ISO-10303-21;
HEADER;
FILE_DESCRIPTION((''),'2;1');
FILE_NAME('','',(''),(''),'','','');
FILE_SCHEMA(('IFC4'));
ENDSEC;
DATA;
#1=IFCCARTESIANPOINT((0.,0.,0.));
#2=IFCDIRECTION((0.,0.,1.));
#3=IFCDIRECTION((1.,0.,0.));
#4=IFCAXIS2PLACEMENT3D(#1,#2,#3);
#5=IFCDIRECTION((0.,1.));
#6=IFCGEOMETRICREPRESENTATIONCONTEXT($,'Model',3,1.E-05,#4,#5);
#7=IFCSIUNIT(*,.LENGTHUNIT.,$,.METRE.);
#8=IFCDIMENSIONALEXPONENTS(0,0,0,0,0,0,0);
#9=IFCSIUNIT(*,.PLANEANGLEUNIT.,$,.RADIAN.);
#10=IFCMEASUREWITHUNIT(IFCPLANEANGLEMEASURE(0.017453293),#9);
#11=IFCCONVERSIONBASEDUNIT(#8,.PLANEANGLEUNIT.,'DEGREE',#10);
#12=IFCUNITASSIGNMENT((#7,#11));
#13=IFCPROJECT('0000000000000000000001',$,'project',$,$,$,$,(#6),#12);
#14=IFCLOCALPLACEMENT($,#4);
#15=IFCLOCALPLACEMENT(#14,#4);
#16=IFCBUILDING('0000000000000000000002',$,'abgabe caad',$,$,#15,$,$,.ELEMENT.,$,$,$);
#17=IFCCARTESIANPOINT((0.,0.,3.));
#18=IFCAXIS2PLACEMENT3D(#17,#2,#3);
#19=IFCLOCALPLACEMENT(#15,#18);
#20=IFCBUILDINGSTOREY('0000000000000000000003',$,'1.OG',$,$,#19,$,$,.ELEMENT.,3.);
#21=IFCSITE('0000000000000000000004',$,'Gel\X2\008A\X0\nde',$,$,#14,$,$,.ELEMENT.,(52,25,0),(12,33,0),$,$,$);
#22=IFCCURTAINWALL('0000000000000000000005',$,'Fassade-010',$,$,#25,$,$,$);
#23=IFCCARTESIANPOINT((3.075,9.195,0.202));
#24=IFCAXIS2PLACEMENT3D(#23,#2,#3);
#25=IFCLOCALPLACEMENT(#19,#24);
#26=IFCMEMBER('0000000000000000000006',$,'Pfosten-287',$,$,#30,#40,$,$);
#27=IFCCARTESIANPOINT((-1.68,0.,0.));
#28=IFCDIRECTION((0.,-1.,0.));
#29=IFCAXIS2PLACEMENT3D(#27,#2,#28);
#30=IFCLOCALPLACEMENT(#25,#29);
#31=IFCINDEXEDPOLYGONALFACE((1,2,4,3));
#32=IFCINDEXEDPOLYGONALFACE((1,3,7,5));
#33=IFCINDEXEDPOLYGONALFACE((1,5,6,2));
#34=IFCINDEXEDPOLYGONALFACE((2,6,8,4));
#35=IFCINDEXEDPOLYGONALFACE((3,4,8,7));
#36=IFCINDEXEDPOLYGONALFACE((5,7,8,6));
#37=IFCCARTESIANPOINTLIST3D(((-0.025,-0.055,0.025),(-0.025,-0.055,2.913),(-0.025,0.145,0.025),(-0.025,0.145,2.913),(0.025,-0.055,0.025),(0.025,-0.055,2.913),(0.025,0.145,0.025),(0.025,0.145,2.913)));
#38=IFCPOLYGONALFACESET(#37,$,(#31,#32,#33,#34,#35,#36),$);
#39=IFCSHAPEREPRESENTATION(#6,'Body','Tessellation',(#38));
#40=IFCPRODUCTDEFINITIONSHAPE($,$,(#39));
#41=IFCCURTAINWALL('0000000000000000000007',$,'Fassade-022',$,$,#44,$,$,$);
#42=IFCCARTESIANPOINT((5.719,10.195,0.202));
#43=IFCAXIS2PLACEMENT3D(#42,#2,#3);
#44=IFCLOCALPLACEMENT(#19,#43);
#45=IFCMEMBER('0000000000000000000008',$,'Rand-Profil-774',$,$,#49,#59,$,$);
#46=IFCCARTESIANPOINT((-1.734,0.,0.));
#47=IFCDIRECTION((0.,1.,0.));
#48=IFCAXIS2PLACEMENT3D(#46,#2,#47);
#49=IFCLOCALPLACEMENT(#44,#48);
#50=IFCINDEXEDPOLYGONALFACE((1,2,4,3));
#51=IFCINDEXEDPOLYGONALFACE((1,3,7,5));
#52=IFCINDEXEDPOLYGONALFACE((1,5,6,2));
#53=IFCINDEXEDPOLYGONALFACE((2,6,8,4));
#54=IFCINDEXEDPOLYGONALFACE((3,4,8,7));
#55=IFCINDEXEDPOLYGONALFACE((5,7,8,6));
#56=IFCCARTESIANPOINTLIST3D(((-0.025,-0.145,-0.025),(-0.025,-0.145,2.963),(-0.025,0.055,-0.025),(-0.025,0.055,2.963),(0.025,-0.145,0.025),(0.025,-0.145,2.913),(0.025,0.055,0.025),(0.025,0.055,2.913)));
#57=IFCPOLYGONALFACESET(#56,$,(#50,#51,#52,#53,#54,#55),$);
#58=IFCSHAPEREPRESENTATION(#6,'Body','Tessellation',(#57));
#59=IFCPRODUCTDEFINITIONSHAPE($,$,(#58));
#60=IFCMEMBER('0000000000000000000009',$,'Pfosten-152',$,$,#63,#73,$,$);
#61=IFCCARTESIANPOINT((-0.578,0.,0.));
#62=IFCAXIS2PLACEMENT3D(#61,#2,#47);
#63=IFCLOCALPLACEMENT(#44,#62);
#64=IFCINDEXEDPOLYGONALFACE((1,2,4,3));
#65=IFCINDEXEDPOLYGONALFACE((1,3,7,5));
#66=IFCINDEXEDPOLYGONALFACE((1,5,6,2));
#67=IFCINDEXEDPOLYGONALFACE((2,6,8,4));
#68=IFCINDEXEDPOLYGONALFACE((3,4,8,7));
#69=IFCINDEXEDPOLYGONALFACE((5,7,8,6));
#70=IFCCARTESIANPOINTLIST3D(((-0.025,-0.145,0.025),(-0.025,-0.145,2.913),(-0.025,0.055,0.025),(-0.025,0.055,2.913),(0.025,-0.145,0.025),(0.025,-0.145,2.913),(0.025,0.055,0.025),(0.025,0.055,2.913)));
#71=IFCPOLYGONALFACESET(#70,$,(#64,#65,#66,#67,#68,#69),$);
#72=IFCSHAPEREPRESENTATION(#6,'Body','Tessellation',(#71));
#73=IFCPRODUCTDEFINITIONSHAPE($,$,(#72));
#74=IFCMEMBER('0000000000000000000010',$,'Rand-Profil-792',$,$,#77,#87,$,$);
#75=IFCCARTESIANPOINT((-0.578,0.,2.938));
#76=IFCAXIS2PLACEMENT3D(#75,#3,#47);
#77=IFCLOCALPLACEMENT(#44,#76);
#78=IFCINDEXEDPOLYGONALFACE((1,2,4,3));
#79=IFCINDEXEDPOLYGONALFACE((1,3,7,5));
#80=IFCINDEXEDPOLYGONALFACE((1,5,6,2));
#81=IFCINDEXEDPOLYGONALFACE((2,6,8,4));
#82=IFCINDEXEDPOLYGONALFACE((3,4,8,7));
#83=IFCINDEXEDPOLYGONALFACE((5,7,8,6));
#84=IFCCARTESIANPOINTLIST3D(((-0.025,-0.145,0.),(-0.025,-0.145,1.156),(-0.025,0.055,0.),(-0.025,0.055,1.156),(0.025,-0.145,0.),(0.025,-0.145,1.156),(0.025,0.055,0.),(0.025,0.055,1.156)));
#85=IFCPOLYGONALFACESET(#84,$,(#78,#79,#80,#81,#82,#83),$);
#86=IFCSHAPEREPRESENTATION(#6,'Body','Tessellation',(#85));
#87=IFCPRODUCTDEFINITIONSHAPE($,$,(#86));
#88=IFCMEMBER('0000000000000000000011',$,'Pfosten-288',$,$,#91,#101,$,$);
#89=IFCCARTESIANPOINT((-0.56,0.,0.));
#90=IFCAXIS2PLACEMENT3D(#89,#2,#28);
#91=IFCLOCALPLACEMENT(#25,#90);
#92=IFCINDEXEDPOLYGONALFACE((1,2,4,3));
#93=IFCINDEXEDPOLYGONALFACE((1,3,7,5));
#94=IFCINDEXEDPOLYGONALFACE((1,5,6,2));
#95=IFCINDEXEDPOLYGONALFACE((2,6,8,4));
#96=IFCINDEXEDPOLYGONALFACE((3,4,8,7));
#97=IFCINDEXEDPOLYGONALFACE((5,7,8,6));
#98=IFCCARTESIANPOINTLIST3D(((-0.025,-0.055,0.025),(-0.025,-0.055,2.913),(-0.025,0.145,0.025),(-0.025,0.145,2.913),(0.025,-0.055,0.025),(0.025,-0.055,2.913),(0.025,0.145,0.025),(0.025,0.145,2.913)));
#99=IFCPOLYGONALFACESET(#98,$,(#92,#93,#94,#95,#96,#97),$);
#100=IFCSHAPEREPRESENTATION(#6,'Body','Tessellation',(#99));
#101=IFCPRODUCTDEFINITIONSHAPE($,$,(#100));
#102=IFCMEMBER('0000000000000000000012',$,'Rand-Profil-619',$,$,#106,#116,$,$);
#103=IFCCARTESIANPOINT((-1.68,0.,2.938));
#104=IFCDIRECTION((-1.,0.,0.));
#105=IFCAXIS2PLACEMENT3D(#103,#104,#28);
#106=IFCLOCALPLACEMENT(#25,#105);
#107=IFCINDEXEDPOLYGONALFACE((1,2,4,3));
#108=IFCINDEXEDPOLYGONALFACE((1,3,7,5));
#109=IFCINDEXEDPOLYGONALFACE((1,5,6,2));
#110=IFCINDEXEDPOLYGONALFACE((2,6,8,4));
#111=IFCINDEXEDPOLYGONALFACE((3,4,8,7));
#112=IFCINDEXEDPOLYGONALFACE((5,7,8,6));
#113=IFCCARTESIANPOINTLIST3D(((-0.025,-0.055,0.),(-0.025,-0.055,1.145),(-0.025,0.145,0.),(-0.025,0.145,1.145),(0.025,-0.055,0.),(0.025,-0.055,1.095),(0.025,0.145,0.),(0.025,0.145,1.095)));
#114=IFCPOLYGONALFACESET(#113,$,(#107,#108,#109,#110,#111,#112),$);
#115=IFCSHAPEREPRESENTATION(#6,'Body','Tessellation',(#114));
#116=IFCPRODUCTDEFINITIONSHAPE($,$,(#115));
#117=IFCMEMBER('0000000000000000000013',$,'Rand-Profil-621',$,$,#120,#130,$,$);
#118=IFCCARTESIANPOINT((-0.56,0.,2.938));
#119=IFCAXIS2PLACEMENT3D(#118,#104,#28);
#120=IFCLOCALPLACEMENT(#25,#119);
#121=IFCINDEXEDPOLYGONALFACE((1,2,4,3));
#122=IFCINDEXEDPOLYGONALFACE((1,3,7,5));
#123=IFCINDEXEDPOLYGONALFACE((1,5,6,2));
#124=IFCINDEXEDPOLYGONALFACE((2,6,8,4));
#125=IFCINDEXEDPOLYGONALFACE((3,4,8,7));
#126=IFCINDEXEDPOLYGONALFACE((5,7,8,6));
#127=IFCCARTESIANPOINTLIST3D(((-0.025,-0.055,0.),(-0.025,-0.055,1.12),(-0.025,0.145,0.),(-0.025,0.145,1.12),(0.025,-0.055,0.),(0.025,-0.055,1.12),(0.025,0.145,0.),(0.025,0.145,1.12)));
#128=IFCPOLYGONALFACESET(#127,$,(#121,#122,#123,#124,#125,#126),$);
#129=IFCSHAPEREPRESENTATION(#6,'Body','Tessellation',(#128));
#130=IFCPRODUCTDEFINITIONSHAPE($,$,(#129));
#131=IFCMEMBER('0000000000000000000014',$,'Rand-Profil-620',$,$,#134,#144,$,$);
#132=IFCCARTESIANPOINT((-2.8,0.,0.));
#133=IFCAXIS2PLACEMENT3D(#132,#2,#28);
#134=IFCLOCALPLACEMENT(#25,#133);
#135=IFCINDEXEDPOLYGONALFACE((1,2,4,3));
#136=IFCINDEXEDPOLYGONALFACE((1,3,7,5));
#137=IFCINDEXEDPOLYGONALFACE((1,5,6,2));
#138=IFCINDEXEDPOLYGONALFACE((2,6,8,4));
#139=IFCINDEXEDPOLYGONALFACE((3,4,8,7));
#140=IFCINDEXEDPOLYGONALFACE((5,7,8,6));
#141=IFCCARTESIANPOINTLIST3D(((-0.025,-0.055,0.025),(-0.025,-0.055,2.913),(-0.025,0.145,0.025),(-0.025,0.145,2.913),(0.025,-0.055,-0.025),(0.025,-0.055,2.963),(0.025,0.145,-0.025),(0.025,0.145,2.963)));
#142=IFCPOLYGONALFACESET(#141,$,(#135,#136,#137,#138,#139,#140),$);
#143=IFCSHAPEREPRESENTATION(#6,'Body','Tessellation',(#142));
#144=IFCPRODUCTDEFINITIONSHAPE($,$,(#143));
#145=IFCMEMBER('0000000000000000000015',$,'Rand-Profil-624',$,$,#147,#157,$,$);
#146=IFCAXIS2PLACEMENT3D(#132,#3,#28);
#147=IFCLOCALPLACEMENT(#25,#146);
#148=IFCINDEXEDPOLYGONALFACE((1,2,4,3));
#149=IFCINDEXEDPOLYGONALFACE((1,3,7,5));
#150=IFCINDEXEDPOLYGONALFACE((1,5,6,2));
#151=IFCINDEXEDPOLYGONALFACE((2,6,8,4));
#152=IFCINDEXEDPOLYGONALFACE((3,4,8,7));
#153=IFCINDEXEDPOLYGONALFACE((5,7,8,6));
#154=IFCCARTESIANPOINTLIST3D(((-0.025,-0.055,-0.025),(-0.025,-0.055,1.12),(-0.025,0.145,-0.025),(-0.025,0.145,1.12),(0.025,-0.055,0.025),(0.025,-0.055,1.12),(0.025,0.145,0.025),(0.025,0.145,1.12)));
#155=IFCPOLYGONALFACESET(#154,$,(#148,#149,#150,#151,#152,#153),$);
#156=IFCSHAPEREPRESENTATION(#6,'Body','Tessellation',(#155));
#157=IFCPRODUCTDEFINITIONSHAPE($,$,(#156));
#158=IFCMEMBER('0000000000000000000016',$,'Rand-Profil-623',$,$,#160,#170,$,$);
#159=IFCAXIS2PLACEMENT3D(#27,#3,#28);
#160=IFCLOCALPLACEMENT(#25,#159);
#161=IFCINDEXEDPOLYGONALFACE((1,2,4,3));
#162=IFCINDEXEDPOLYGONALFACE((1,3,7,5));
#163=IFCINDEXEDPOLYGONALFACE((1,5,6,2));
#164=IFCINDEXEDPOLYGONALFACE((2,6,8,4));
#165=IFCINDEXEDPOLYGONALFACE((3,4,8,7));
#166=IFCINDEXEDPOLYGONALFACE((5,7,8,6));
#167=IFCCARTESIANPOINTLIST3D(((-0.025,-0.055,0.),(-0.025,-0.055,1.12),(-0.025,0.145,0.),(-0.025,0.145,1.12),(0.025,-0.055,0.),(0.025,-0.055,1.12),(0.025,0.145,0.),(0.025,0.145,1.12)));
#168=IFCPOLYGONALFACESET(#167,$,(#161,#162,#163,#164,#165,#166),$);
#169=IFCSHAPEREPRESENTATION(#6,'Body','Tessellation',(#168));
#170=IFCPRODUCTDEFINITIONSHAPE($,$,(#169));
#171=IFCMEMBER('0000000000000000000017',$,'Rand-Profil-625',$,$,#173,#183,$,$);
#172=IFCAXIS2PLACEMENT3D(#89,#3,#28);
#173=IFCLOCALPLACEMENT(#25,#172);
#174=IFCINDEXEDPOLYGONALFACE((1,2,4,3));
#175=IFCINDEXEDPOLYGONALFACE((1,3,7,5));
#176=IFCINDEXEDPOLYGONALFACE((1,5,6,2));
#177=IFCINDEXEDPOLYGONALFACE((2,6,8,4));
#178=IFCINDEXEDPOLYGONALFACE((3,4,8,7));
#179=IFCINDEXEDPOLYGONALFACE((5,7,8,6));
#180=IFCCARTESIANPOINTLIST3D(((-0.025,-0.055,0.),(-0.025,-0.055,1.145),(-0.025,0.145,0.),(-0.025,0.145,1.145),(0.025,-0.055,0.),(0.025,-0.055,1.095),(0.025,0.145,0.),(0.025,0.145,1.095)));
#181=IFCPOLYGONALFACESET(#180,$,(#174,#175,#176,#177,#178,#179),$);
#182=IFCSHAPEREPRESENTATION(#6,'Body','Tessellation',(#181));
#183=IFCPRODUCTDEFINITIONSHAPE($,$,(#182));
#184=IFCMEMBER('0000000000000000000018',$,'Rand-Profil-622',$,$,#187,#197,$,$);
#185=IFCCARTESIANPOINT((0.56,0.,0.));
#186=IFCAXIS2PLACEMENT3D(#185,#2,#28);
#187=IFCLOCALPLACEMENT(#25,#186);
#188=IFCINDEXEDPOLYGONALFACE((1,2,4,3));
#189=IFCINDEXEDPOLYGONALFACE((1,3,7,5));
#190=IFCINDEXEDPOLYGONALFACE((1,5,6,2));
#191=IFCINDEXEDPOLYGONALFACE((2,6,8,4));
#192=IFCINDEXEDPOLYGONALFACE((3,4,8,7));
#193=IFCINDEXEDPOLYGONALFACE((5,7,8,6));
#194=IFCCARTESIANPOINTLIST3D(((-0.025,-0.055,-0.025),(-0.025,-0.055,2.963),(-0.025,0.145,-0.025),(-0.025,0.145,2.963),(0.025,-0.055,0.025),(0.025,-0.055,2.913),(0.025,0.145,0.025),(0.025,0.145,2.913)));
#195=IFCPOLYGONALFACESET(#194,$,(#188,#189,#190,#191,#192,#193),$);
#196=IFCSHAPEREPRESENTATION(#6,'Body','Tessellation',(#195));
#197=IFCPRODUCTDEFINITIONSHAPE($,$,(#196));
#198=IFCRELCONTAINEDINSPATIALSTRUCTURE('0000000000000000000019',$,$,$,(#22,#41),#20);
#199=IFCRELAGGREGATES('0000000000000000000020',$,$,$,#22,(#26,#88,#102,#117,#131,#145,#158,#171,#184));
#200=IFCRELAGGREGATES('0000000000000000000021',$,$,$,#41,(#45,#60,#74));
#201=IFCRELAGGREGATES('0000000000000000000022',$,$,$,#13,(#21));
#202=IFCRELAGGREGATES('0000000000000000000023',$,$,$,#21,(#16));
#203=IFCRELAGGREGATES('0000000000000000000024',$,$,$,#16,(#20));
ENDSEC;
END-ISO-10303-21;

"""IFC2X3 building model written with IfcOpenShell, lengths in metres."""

from ifc_helpers import new_model, entity, si_unit, converted_unit, direction, frame, origin_with_axes, place, context, project, spatial, polyline, outline, extrude, clip, halfspace, element, aggregate, save


model = new_model("IFC2X3")

# Units and contexts
model_context = context("Model", 3, precision=1e-05, world=origin_with_axes(), true_north=direction((0.0, 1.0)))
ifc_project = project(units=[si_unit("LENGTHUNIT", "METRE"), converted_unit("PLANEANGLEUNIT", "DEGREE", entity("IfcPlaneAngleMeasure", 0.017453293), si_unit("PLANEANGLEUNIT", "RADIAN"), dimensions=[0, 0, 0, 0, 0, 0, 0])], contexts=[model_context])

# Site, building, storey
site_placement = place(None, origin_with_axes())
site = spatial("IfcSite", under=ifc_project, at=site_placement, Name="Gel\u008ande", CompositionType="ELEMENT", RefLatitude=(52, 25, 0), RefLongitude=(12, 33, 0))
building_placement = place(site_placement, origin_with_axes())
building = spatial("IfcBuilding", under=site, at=building_placement, Name="abgabe caad", CompositionType="ELEMENT")
storey_placement = place(building_placement, frame((0.0, 0.0, 3.0), z_axis=(0.0, 0.0, 1.0), x_axis=(1.0, 0.0, 0.0)))
storey = spatial("IfcBuildingStorey", under=building, at=storey_placement, Name="1.OG", CompositionType="ELEMENT", Elevation=3.0)

# Curtain wall, member
curtain_wall_1_placement = place(storey_placement, frame((3.075, 9.195, 0.202), z_axis=(0.0, 0.0, 1.0), x_axis=(1.0, 0.0, 0.0)))
curtain_wall_1 = element("IfcCurtainWall", 1, at=curtain_wall_1_placement, inside=storey, Name="Fassade-010")
member_1_placement = place(curtain_wall_1_placement, frame((-1.68, 0.0, 0.0), z_axis=(0.0, 0.0, 1.0), x_axis=(0.0, -1.0, 0.0)))
member_1 = element("IfcMember", 2, at=member_1_placement, Name="Pfosten-287", context=model_context, shape_type="SweptSolid", body=[
    extrude(outline(polyline([(0.145, -0.025), (0.145, 0.025), (-0.055, 0.025), (-0.055, -0.025), (0.145, -0.025)])), frame((0.0, 0.0, 0.025), z_axis=(0.0, 0.0, 1.0), x_axis=(0.0, 1.0, 0.0)), (0.0, 0.0, 1.0), 2.888),
])

# Curtain wall, members
curtain_wall_2_placement = place(storey_placement, frame((5.719, 10.195, 0.202), z_axis=(0.0, 0.0, 1.0), x_axis=(1.0, 0.0, 0.0)))
curtain_wall_2 = element("IfcCurtainWall", 3, at=curtain_wall_2_placement, inside=storey, Name="Fassade-022")
member_2_placement = place(curtain_wall_2_placement, frame((-1.734, 0.0, 0.0), z_axis=(0.0, 0.0, 1.0), x_axis=(0.0, 1.0, 0.0)))
member_2 = element("IfcMember", 4, at=member_2_placement, Name="Rand-Profil-774", context=model_context, shape_type="Clipping", body=[
    clip(clip(extrude(outline(polyline([(0.145, 0.025), (-0.055, 0.025), (-0.055, -0.025), (0.145, -0.025), (0.145, 0.025)])), frame((0.0, 0.0, -0.025), z_axis=(0.0, 0.0, 1.0), x_axis=(0.0, -1.0, 0.0)), (0.0, 0.0, 1.0), 2.988), halfspace(frame((0.0, 0.0, 0.0), z_axis=(-0.707107, 0.0, 0.707107), x_axis=(-0.707107, 0.0, -0.707107)), True)), halfspace(frame((1.469, 0.0, 1.469), z_axis=(-0.707107, 0.0, -0.707107), x_axis=(0.707107, 0.0, -0.707107)), True)),
])
member_3_placement = place(curtain_wall_2_placement, frame((-0.578, 0.0, 0.0), z_axis=(0.0, 0.0, 1.0), x_axis=(0.0, 1.0, 0.0)))
member_3 = element("IfcMember", 5, at=member_3_placement, Name="Pfosten-152", context=model_context, shape_type="SweptSolid", body=[
    extrude(outline(polyline([(0.145, 0.025), (-0.055, 0.025), (-0.055, -0.025), (0.145, -0.025), (0.145, 0.025)])), frame((0.0, 0.0, 0.025), z_axis=(0.0, 0.0, 1.0), x_axis=(0.0, -1.0, 0.0)), (0.0, 0.0, 1.0), 2.888),
])
member_4_placement = place(curtain_wall_2_placement, frame((-0.578, 0.0, 2.938), z_axis=(1.0, 0.0, 0.0), x_axis=(0.0, 1.0, 0.0)))
member_4 = element("IfcMember", 6, at=member_4_placement, Name="Rand-Profil-792", context=model_context, shape_type="SweptSolid", body=[
    extrude(outline(polyline([(-0.025, 0.145), (-0.025, -0.055), (0.025, -0.055), (0.025, 0.145), (-0.025, 0.145)])), frame((0.0, 0.0, 0.0), z_axis=(0.0, 0.0, 1.0), x_axis=(-1.0, 0.0, 0.0)), (0.0, 0.0, 1.0), 1.156),
])

# Members
member_5_placement = place(curtain_wall_1_placement, frame((-0.56, 0.0, 0.0), z_axis=(0.0, 0.0, 1.0), x_axis=(0.0, -1.0, 0.0)))
member_5 = element("IfcMember", 7, at=member_5_placement, Name="Pfosten-288", context=model_context, shape_type="SweptSolid", body=[
    extrude(outline(polyline([(0.145, -0.025), (0.145, 0.025), (-0.055, 0.025), (-0.055, -0.025), (0.145, -0.025)])), frame((0.0, 0.0, 0.025), z_axis=(0.0, 0.0, 1.0), x_axis=(0.0, 1.0, 0.0)), (0.0, 0.0, 1.0), 2.888),
])
member_6_placement = place(curtain_wall_1_placement, frame((-1.68, 0.0, 2.938), z_axis=(-1.0, 0.0, 0.0), x_axis=(0.0, -1.0, 0.0)))
member_6 = element("IfcMember", 8, at=member_6_placement, Name="Rand-Profil-619", context=model_context, shape_type="Clipping", body=[
    clip(extrude(outline(polyline([(-0.025, -0.145), (0.025, -0.145), (0.025, 0.055), (-0.025, 0.055), (-0.025, -0.145)])), frame((0.0, 0.0, 0.0), z_axis=(0.0, 0.0, 1.0), x_axis=(-1.0, 0.0, 0.0)), (0.0, 0.0, 1.0), 1.145), halfspace(frame((0.56, 0.0, 0.56), z_axis=(-0.707107, 0.0, -0.707107), x_axis=(0.707107, 0.0, -0.707107)), True)),
])
member_7_placement = place(curtain_wall_1_placement, frame((-0.56, 0.0, 2.938), z_axis=(-1.0, 0.0, 0.0), x_axis=(0.0, -1.0, 0.0)))
member_7 = element("IfcMember", 9, at=member_7_placement, Name="Rand-Profil-621", context=model_context, shape_type="SweptSolid", body=[
    extrude(outline(polyline([(-0.025, -0.145), (0.025, -0.145), (0.025, 0.055), (-0.025, 0.055), (-0.025, -0.145)])), frame((0.0, 0.0, 0.0), z_axis=(0.0, 0.0, 1.0), x_axis=(-1.0, 0.0, 0.0)), (0.0, 0.0, 1.0), 1.12),
])
member_8_placement = place(curtain_wall_1_placement, frame((-2.8, 0.0, 0.0), z_axis=(0.0, 0.0, 1.0), x_axis=(0.0, -1.0, 0.0)))
member_8 = element("IfcMember", 10, at=member_8_placement, Name="Rand-Profil-620", context=model_context, shape_type="Clipping", body=[
    clip(clip(extrude(outline(polyline([(0.145, -0.025), (0.145, 0.025), (-0.055, 0.025), (-0.055, -0.025), (0.145, -0.025)])), frame((0.0, 0.0, -0.025), z_axis=(0.0, 0.0, 1.0), x_axis=(0.0, 1.0, 0.0)), (0.0, 0.0, 1.0), 2.988), halfspace(frame((0.0, 0.0, 0.0), z_axis=(0.707107, 0.0, 0.707107), x_axis=(-0.707107, 0.0, 0.707107)), True)), halfspace(frame((-1.469, 0.0, 1.469), z_axis=(0.707107, 0.0, -0.707107), x_axis=(0.707107, 0.0, 0.707107)), True)),
])
member_9_placement = place(curtain_wall_1_placement, frame((-2.8, 0.0, 0.0), z_axis=(1.0, 0.0, 0.0), x_axis=(0.0, -1.0, 0.0)))
member_9 = element("IfcMember", 11, at=member_9_placement, Name="Rand-Profil-624", context=model_context, shape_type="Clipping", body=[
    clip(extrude(outline(polyline([(0.025, 0.145), (-0.025, 0.145), (-0.025, -0.055), (0.025, -0.055), (0.025, 0.145)])), frame((0.0, 0.0, -0.025), z_axis=(0.0, 0.0, 1.0), x_axis=(1.0, 0.0, 0.0)), (0.0, 0.0, 1.0), 1.145), halfspace(frame((0.0, 0.0, 0.0), z_axis=(-0.707107, 0.0, 0.707107), x_axis=(-0.707107, 0.0, -0.707107)), True)),
])
member_10_placement = place(curtain_wall_1_placement, frame((-1.68, 0.0, 0.0), z_axis=(1.0, 0.0, 0.0), x_axis=(0.0, -1.0, 0.0)))
member_10 = element("IfcMember", 12, at=member_10_placement, Name="Rand-Profil-623", context=model_context, shape_type="SweptSolid", body=[
    extrude(outline(polyline([(0.025, 0.145), (-0.025, 0.145), (-0.025, -0.055), (0.025, -0.055), (0.025, 0.145)])), origin_with_axes(), (0.0, 0.0, 1.0), 1.12),
])
member_11_placement = place(curtain_wall_1_placement, frame((-0.56, 0.0, 0.0), z_axis=(1.0, 0.0, 0.0), x_axis=(0.0, -1.0, 0.0)))
member_11 = element("IfcMember", 13, at=member_11_placement, Name="Rand-Profil-625", context=model_context, shape_type="Clipping", body=[
    clip(extrude(outline(polyline([(0.025, 0.145), (-0.025, 0.145), (-0.025, -0.055), (0.025, -0.055), (0.025, 0.145)])), origin_with_axes(), (0.0, 0.0, 1.0), 1.145), halfspace(frame((0.56, 0.0, 0.56), z_axis=(-0.707107, 0.0, -0.707107), x_axis=(0.707107, 0.0, -0.707107)), True)),
])
member_12_placement = place(curtain_wall_1_placement, frame((0.56, 0.0, 0.0), z_axis=(0.0, 0.0, 1.0), x_axis=(0.0, -1.0, 0.0)))
member_12 = element("IfcMember", 14, at=member_12_placement, Name="Rand-Profil-622", context=model_context, shape_type="Clipping", body=[
    clip(clip(extrude(outline(polyline([(0.145, -0.025), (0.145, 0.025), (-0.055, 0.025), (-0.055, -0.025), (0.145, -0.025)])), frame((0.0, 0.0, -0.025), z_axis=(0.0, 0.0, 1.0), x_axis=(0.0, 1.0, 0.0)), (0.0, 0.0, 1.0), 2.988), halfspace(frame((0.0, 0.0, 0.0), z_axis=(-0.707107, 0.0, 0.707107), x_axis=(-0.707107, 0.0, -0.707107)), True)), halfspace(frame((1.469, 0.0, 1.469), z_axis=(-0.707107, 0.0, -0.707107), x_axis=(0.707107, 0.0, -0.707107)), True)),
])

aggregate(curtain_wall_1, [member_1, member_5, member_6, member_7, member_8, member_9, member_10, member_11, member_12])
aggregate(curtain_wall_2, [member_2, member_3, member_4])

save(model, "model.ifc")
